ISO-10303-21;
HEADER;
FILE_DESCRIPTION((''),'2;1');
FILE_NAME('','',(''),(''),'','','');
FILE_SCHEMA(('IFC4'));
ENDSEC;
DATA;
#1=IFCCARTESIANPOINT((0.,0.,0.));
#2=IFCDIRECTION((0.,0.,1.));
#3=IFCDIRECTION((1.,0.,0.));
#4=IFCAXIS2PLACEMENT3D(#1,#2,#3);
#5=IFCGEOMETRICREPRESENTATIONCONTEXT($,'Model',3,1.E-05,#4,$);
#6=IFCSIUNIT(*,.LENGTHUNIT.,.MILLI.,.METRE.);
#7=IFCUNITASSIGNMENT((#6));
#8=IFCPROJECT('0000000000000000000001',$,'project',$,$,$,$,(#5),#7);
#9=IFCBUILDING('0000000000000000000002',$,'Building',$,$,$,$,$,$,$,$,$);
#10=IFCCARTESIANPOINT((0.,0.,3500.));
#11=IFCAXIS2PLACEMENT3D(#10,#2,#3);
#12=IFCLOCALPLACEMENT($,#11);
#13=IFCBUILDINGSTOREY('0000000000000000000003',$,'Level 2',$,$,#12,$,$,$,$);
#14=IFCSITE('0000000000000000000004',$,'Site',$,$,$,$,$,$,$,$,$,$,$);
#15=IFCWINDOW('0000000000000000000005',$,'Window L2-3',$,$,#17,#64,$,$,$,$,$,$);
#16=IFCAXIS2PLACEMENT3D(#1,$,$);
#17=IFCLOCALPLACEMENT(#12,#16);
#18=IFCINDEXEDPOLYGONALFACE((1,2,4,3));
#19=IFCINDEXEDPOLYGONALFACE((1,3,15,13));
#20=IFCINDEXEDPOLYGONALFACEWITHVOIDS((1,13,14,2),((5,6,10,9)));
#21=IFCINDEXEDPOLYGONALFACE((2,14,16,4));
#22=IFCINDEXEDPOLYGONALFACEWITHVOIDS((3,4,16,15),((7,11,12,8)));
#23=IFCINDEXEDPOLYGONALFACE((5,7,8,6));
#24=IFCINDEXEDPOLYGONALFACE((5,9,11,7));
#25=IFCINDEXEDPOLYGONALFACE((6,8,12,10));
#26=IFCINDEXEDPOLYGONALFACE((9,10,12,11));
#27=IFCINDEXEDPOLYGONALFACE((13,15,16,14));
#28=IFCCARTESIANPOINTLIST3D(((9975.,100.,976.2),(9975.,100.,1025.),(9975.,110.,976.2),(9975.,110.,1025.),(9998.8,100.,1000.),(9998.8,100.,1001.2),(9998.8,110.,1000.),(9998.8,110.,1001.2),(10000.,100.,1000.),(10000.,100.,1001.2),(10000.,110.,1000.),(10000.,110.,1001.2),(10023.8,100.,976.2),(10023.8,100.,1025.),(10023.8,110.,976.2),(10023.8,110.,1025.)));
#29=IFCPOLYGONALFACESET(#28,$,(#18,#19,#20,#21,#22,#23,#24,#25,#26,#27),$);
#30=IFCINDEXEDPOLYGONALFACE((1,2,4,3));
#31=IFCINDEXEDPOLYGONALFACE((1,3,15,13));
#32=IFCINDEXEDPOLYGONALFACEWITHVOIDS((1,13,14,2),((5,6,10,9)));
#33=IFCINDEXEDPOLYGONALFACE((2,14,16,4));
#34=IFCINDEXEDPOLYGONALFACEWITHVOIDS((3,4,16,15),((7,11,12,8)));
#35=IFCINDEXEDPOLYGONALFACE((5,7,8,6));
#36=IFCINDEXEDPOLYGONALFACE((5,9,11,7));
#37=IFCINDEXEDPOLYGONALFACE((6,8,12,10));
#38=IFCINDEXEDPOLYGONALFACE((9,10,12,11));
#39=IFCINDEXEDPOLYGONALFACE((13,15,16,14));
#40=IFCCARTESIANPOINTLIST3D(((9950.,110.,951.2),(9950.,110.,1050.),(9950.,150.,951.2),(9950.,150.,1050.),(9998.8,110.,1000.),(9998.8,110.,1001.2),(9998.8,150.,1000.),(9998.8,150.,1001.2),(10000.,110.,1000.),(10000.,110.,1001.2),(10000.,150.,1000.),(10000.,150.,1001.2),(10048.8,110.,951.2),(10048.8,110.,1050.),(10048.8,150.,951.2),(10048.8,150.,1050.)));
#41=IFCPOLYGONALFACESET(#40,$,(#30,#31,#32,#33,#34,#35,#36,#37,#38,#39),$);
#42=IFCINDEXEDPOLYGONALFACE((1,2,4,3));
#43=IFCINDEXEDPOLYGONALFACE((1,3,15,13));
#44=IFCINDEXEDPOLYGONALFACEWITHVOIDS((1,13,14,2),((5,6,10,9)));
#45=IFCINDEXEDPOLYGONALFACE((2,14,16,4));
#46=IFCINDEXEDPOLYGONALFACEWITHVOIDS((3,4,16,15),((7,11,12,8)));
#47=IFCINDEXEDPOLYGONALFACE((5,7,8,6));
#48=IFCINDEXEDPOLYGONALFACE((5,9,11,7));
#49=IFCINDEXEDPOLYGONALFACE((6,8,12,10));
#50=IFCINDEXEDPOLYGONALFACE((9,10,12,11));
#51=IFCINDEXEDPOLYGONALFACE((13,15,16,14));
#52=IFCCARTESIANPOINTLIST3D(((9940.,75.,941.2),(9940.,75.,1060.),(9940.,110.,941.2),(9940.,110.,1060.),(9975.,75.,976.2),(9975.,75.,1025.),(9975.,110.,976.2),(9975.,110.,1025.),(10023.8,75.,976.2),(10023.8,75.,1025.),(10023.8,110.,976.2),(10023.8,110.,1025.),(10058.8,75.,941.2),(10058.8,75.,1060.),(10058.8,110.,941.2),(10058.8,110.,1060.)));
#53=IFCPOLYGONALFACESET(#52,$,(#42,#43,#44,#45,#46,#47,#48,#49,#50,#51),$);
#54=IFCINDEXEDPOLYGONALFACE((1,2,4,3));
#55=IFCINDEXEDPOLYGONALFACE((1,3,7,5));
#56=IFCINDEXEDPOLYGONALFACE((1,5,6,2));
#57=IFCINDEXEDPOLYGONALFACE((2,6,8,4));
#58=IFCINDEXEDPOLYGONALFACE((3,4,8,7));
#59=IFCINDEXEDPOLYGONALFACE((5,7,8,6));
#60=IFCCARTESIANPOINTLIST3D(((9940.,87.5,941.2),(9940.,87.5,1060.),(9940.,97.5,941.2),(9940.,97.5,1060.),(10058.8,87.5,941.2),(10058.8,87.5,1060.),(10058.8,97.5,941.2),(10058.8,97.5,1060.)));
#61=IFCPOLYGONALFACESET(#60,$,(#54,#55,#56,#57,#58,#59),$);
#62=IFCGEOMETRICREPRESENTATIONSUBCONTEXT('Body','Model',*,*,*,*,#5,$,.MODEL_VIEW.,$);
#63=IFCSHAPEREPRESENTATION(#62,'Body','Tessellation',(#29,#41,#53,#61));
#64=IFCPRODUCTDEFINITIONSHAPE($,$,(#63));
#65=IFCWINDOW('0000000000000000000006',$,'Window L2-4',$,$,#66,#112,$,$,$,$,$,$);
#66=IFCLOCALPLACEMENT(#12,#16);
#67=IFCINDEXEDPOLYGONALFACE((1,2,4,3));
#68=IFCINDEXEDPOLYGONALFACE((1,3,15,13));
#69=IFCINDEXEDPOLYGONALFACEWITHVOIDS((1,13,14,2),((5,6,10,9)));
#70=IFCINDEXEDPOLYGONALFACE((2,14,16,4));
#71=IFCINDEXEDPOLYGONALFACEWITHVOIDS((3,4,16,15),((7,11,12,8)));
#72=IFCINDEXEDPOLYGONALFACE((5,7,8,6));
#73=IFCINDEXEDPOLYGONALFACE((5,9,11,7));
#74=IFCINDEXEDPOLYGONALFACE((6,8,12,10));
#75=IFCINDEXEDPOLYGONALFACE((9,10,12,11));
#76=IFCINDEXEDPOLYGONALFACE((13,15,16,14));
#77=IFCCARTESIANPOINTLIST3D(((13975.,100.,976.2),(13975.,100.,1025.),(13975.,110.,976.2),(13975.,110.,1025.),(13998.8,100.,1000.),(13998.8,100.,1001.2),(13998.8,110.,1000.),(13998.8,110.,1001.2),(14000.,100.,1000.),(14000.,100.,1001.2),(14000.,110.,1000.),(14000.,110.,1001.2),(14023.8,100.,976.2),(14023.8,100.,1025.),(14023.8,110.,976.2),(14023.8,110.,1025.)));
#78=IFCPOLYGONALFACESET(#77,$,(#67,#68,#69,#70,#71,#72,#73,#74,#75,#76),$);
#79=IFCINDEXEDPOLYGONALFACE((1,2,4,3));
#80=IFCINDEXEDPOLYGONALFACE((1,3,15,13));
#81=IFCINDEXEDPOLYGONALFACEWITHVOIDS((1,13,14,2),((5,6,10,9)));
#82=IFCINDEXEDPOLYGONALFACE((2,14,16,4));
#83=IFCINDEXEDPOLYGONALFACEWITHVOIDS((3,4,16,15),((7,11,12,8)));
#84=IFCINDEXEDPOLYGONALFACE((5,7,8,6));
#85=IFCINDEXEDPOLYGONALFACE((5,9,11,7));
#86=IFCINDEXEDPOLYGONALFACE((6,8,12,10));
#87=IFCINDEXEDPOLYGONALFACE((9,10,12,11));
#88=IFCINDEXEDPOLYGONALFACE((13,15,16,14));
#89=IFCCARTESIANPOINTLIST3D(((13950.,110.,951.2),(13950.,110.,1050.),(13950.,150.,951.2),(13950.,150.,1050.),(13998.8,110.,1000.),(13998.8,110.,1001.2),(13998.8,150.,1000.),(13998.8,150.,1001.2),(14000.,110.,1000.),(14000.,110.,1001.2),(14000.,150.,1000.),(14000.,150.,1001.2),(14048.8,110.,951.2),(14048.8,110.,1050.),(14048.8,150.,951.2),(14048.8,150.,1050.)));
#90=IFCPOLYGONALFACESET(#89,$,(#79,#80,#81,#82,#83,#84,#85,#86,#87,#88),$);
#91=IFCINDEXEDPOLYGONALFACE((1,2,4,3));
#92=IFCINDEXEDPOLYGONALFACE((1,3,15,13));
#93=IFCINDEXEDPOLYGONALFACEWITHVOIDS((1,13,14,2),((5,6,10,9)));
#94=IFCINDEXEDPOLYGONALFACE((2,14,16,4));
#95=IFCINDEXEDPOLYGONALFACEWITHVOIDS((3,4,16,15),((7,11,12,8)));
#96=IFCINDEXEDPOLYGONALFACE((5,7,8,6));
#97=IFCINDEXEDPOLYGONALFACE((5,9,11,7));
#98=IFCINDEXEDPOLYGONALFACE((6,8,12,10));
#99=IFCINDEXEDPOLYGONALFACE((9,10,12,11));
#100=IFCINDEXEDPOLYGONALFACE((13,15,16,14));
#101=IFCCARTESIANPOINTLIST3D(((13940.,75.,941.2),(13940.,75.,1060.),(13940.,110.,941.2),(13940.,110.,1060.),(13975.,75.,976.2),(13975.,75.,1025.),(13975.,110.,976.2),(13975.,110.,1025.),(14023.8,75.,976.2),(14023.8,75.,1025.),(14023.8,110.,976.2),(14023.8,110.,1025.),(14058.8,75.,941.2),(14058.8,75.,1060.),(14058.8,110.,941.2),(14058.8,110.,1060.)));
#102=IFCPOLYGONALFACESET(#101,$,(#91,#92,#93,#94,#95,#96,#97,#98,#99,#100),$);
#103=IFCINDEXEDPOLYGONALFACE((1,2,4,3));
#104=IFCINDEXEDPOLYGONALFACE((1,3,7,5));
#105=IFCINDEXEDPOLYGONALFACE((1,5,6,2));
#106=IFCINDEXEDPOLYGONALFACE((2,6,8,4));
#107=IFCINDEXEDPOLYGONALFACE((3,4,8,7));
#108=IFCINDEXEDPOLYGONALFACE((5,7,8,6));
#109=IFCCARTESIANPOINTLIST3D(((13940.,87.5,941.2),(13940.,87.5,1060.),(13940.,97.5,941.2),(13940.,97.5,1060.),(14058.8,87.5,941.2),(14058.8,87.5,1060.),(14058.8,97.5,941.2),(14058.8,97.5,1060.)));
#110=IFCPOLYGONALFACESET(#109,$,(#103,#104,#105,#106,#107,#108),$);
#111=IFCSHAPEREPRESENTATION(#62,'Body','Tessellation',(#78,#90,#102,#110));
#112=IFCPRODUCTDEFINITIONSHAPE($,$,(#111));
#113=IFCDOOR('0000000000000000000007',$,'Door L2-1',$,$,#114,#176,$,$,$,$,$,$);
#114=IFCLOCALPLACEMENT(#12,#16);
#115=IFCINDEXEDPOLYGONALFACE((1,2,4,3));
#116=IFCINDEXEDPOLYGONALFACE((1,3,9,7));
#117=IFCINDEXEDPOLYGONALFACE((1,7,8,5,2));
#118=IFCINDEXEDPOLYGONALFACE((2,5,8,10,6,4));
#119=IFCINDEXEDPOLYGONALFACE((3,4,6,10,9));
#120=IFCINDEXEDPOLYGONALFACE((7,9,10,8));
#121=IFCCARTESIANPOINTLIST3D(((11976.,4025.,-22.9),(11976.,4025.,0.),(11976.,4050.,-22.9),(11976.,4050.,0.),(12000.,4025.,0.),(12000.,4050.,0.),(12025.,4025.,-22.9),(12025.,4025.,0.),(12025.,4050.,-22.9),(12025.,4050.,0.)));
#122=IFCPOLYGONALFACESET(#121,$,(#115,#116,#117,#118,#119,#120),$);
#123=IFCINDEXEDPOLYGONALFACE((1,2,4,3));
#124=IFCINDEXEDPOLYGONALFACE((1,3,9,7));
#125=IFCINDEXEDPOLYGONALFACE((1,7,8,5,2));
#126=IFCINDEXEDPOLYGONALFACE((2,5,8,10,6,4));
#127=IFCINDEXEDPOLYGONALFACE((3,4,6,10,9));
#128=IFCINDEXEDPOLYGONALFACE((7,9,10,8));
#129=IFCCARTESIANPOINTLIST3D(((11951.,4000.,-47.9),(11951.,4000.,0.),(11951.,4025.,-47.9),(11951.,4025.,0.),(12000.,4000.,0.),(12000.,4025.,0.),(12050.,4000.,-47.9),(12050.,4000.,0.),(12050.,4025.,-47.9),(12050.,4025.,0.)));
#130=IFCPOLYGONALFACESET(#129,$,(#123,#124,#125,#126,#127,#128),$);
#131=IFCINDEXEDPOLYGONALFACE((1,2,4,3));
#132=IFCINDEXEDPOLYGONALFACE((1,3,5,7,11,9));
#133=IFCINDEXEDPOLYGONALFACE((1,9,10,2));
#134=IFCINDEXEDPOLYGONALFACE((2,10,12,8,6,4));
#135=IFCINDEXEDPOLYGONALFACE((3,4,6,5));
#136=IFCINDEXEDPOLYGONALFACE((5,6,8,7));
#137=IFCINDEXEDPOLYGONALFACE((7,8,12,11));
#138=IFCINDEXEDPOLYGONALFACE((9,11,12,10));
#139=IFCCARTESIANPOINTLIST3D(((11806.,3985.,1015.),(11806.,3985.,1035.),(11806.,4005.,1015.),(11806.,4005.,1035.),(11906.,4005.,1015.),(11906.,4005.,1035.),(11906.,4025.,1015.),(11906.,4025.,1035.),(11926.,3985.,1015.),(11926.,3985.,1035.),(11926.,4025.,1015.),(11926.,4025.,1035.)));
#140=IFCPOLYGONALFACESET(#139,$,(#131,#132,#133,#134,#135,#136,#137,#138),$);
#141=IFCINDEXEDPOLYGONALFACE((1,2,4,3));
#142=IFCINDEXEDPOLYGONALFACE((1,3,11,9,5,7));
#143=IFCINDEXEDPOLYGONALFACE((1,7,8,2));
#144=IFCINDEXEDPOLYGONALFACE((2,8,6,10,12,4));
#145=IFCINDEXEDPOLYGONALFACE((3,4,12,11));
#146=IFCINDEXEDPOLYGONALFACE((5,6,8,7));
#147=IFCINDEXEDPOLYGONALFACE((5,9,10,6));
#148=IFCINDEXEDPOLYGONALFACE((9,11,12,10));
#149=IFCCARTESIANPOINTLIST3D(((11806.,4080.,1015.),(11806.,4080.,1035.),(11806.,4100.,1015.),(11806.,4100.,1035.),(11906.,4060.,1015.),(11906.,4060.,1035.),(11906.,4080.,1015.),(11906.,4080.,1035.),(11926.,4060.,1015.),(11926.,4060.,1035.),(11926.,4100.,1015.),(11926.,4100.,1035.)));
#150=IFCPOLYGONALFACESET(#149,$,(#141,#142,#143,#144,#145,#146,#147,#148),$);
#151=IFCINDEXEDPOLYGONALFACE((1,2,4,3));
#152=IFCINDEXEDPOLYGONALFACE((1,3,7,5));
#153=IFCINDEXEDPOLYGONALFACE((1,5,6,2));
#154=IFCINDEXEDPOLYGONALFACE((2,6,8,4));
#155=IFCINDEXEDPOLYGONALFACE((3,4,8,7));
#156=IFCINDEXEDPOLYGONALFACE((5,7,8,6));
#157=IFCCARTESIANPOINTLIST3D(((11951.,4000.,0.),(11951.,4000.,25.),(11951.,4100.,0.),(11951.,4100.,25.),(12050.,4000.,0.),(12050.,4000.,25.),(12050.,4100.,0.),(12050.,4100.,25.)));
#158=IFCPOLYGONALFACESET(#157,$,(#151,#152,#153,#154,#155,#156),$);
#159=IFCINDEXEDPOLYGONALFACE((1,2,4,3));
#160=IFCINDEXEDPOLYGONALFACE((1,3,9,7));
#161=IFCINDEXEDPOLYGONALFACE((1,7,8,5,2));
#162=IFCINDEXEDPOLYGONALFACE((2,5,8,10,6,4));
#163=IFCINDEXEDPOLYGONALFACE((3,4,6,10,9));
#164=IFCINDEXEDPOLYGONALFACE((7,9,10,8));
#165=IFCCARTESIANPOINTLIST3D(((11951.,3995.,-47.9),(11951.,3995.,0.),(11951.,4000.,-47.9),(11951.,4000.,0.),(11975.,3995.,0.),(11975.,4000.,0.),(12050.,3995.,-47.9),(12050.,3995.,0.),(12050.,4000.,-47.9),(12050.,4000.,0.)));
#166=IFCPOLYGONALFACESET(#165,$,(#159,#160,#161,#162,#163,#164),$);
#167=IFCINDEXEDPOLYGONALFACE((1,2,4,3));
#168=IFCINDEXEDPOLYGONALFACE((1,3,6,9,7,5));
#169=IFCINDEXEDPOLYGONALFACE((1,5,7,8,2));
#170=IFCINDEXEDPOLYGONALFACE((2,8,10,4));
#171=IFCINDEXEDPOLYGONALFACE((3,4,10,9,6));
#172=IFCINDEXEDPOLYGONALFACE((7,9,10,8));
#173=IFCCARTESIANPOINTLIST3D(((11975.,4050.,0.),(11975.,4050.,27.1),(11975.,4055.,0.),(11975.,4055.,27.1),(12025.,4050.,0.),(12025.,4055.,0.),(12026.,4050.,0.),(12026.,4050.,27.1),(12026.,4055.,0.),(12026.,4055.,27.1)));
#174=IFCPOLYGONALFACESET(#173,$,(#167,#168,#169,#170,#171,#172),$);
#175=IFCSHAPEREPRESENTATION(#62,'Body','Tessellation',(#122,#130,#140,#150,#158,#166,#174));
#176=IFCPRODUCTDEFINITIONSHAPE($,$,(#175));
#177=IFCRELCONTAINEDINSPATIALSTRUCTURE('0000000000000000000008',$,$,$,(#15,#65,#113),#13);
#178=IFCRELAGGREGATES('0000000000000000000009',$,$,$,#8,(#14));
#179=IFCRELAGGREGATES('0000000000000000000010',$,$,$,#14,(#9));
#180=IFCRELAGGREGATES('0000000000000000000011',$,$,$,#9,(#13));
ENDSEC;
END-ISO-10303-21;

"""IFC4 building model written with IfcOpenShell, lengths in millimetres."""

from ifc_helpers import new_model, si_unit, frame, origin_with_axes, place, context, subcontext, project, spatial, line, indexed_curve, outline, extrude, element, save


model = new_model("IFC4")

# Units and contexts
model_context = context("Model", 3, precision=1e-05, world=origin_with_axes())
body_context = subcontext(model_context, "Body", "Model", "MODEL_VIEW")
ifc_project = project(units=[si_unit("LENGTHUNIT", "METRE", prefix="MILLI")], contexts=[model_context])

# Site, building, storey
site = spatial("IfcSite", under=ifc_project, Name="Site")
building = spatial("IfcBuilding", under=site, Name="Building")
storey_placement = place(None, frame((0.0, 0.0, 3500.0), z_axis=(0.0, 0.0, 1.0), x_axis=(1.0, 0.0, 0.0)))
storey = spatial("IfcBuildingStorey", under=building, at=storey_placement, Name="Level 2")

# Windows
for number, where, z_axis, x_axis, name in (
    (1, (10000.0, 200.0, 1000.0), (0.0, 0.0, 1.0), (-1.0, 0.0, 0.0), "Window L2-3"),
    (2, (14000.0, 200.0, 1000.0), (0.0, 0.0, 1.0), (-1.0, 0.0, 0.0), "Window L2-4"),
):
    element("IfcWindow", number, at=place(storey_placement, frame(where, z_axis=z_axis, x_axis=x_axis)), inside=storey, Name=name, context=body_context, shape_type="SweptSolid", body=[
        extrude(outline(indexed_curve([(0.0, 0.0), (1.2, 0.0), (1.2, 1.2), (0.0, 1.2)], segments=[line(1, 2, 3, 4, 1)]), holes=[indexed_curve([(25.0, 25.0), (-23.8, 25.0), (-23.8, -23.8), (25.0, -23.8)], segments=[line(1, 2, 3, 4, 1)])]), frame((0.0, 90.0, 0.0), z_axis=(0.0, -1.0, 0.0), x_axis=(1.0, 0.0, 0.0)), (0.0, 0.0, -1.0), 10.0),
        extrude(outline(indexed_curve([(0.0, 0.0), (1.2, 0.0), (1.2, 1.2), (0.0, 1.2)], segments=[line(1, 2, 3, 4, 1)]), holes=[indexed_curve([(50.0, 50.0), (-48.8, 50.0), (-48.8, -48.8), (50.0, -48.8)], segments=[line(1, 2, 3, 4, 1)])]), frame((0.0, 50.0, 0.0), z_axis=(0.0, -1.0, 0.0), x_axis=(1.0, 0.0, 0.0)), (0.0, 0.0, -1.0), 40.0),
        extrude(outline(indexed_curve([(0.0, 0.0), (-48.8, 0.0), (-48.8, -48.8), (0.0, -48.8)], segments=[line(1, 2, 3, 4, 1)]), holes=[indexed_curve([(35.0, 35.0), (-83.8, 35.0), (-83.8, -83.8), (35.0, -83.8)], segments=[line(1, 2, 3, 4, 1)])]), frame((25.0, 90.0, 25.0), z_axis=(0.0, -1.0, 0.0), x_axis=(1.0, 0.0, 0.0)), (0.0, 0.0, -1.0), 35.0),
        extrude(outline(indexed_curve([(35.0, 35.0), (-83.8, 35.0), (-83.8, -83.8), (35.0, -83.8)], segments=[line(1, 2, 3, 4, 1)])), frame((25.0, 102.5, 25.0), z_axis=(0.0, -1.0, 0.0), x_axis=(1.0, 0.0, 0.0)), (0.0, 0.0, -1.0), 10.0),
    ])

# Door
door_1_placement = place(storey_placement, frame((12000.0, 4000.0, 0.0), z_axis=(0.0, 0.0, 1.0), x_axis=(1.0, 0.0, 0.0)))
element("IfcDoor", 3, at=door_1_placement, inside=storey, Name="Door L2-1", context=body_context, shape_type="SweptSolid", body=[
    extrude(outline(indexed_curve([(0.0, 0.0), (0.0, 2.1), (1.0, 2.1), (1.0, 0.0), (-24.0, 0.0), (-24.0, -22.9), (25.0, -22.9), (25.0, 0.0)], segments=[line(1, 2, 3, 4, 5, 6, 7, 8, 1)])), frame((0.0, 25.0, 0.0), z_axis=(0.0, -1.0, 0.0), x_axis=(1.0, 0.0, 0.0)), (0.0, 0.0, -1.0), 25.0),
    extrude(outline(indexed_curve([(0.0, 0.0), (0.0, 2.1), (1.0, 2.1), (1.0, 0.0), (-49.0, 0.0), (-49.0, -47.9), (50.0, -47.9), (50.0, 0.0)], segments=[line(1, 2, 3, 4, 5, 6, 7, 8, 1)])), frame((0.0, 0.0, 0.0), z_axis=(0.0, -1.0, 0.0), x_axis=(1.0, 0.0, 0.0)), (0.0, 0.0, -1.0), 25.0),
    extrude(outline(indexed_curve([(0.0, 0.0), (-49.0, 0.0), (-49.0, 35.0), (0.0, 35.0)], segments=[line(1, 2, 3, 4, 1)])), frame((25.0, 25.0, 25.0), z_axis=(0.0, 0.0, 1.0), x_axis=(1.0, 0.0, 0.0)), (0.0, 0.0, 1.0), -47.9),
    extrude(outline(indexed_curve([(0.0, 0.0), (0.0, -40.0), (-120.0, -40.0), (-120.0, -20.0), (-20.0, -20.0), (-20.0, 0.0)], segments=[line(1, 2, 3, 4, 5, 6, 1)])), frame((-74.0, 25.0, 1015.0), z_axis=(0.0, 0.0, 1.0), x_axis=(1.0, 0.0, 0.0)), (0.0, 0.0, 1.0), 20.0),
    extrude(outline(indexed_curve([(0.0, 0.0), (0.0, 40.0), (-120.0, 40.0), (-120.0, 20.0), (-20.0, 20.0), (-20.0, 0.0)], segments=[line(1, 2, 3, 4, 5, 6, 1)])), frame((-74.0, 60.0, 1015.0), z_axis=(0.0, 0.0, 1.0), x_axis=(1.0, 0.0, 0.0)), (0.0, 0.0, 1.0), 20.0),
    extrude(outline(indexed_curve([(0.0, 0.0), (-99.0, 0.0), (-99.0, 100.0), (0.0, 100.0)], segments=[line(1, 2, 3, 4, 1)])), frame((50.0, 0.0, 0.0), z_axis=(0.0, 0.0, 1.0), x_axis=(1.0, 0.0, 0.0)), (0.0, 0.0, 1.0), 25.0),
    extrude(outline(indexed_curve([(0.0, 0.0), (0.0, 27.1), (51.0, 27.1), (51.0, 0.0), (-24.0, 0.0), (-24.0, -47.9), (75.0, -47.9), (75.0, 0.0)], segments=[line(1, 2, 3, 4, 5, 6, 7, 8, 1)])), frame((-25.0, -5.0, 0.0), z_axis=(0.0, -1.0, 0.0), x_axis=(1.0, 0.0, 0.0)), (0.0, 0.0, -1.0), 5.0),
    extrude(outline(indexed_curve([(0.0, 0.0), (0.0, 27.1), (51.0, 27.1), (51.0, 0.0), (1.0, 0.0), (1.0, -22.9), (50.0, -22.9), (50.0, 0.0)], segments=[line(1, 2, 3, 4, 5, 6, 7, 8, 1)])), frame((-25.0, 50.0, 0.0), z_axis=(0.0, -1.0, 0.0), x_axis=(1.0, 0.0, 0.0)), (0.0, 0.0, -1.0), 5.0),
])

save(model, "model.ifc")
